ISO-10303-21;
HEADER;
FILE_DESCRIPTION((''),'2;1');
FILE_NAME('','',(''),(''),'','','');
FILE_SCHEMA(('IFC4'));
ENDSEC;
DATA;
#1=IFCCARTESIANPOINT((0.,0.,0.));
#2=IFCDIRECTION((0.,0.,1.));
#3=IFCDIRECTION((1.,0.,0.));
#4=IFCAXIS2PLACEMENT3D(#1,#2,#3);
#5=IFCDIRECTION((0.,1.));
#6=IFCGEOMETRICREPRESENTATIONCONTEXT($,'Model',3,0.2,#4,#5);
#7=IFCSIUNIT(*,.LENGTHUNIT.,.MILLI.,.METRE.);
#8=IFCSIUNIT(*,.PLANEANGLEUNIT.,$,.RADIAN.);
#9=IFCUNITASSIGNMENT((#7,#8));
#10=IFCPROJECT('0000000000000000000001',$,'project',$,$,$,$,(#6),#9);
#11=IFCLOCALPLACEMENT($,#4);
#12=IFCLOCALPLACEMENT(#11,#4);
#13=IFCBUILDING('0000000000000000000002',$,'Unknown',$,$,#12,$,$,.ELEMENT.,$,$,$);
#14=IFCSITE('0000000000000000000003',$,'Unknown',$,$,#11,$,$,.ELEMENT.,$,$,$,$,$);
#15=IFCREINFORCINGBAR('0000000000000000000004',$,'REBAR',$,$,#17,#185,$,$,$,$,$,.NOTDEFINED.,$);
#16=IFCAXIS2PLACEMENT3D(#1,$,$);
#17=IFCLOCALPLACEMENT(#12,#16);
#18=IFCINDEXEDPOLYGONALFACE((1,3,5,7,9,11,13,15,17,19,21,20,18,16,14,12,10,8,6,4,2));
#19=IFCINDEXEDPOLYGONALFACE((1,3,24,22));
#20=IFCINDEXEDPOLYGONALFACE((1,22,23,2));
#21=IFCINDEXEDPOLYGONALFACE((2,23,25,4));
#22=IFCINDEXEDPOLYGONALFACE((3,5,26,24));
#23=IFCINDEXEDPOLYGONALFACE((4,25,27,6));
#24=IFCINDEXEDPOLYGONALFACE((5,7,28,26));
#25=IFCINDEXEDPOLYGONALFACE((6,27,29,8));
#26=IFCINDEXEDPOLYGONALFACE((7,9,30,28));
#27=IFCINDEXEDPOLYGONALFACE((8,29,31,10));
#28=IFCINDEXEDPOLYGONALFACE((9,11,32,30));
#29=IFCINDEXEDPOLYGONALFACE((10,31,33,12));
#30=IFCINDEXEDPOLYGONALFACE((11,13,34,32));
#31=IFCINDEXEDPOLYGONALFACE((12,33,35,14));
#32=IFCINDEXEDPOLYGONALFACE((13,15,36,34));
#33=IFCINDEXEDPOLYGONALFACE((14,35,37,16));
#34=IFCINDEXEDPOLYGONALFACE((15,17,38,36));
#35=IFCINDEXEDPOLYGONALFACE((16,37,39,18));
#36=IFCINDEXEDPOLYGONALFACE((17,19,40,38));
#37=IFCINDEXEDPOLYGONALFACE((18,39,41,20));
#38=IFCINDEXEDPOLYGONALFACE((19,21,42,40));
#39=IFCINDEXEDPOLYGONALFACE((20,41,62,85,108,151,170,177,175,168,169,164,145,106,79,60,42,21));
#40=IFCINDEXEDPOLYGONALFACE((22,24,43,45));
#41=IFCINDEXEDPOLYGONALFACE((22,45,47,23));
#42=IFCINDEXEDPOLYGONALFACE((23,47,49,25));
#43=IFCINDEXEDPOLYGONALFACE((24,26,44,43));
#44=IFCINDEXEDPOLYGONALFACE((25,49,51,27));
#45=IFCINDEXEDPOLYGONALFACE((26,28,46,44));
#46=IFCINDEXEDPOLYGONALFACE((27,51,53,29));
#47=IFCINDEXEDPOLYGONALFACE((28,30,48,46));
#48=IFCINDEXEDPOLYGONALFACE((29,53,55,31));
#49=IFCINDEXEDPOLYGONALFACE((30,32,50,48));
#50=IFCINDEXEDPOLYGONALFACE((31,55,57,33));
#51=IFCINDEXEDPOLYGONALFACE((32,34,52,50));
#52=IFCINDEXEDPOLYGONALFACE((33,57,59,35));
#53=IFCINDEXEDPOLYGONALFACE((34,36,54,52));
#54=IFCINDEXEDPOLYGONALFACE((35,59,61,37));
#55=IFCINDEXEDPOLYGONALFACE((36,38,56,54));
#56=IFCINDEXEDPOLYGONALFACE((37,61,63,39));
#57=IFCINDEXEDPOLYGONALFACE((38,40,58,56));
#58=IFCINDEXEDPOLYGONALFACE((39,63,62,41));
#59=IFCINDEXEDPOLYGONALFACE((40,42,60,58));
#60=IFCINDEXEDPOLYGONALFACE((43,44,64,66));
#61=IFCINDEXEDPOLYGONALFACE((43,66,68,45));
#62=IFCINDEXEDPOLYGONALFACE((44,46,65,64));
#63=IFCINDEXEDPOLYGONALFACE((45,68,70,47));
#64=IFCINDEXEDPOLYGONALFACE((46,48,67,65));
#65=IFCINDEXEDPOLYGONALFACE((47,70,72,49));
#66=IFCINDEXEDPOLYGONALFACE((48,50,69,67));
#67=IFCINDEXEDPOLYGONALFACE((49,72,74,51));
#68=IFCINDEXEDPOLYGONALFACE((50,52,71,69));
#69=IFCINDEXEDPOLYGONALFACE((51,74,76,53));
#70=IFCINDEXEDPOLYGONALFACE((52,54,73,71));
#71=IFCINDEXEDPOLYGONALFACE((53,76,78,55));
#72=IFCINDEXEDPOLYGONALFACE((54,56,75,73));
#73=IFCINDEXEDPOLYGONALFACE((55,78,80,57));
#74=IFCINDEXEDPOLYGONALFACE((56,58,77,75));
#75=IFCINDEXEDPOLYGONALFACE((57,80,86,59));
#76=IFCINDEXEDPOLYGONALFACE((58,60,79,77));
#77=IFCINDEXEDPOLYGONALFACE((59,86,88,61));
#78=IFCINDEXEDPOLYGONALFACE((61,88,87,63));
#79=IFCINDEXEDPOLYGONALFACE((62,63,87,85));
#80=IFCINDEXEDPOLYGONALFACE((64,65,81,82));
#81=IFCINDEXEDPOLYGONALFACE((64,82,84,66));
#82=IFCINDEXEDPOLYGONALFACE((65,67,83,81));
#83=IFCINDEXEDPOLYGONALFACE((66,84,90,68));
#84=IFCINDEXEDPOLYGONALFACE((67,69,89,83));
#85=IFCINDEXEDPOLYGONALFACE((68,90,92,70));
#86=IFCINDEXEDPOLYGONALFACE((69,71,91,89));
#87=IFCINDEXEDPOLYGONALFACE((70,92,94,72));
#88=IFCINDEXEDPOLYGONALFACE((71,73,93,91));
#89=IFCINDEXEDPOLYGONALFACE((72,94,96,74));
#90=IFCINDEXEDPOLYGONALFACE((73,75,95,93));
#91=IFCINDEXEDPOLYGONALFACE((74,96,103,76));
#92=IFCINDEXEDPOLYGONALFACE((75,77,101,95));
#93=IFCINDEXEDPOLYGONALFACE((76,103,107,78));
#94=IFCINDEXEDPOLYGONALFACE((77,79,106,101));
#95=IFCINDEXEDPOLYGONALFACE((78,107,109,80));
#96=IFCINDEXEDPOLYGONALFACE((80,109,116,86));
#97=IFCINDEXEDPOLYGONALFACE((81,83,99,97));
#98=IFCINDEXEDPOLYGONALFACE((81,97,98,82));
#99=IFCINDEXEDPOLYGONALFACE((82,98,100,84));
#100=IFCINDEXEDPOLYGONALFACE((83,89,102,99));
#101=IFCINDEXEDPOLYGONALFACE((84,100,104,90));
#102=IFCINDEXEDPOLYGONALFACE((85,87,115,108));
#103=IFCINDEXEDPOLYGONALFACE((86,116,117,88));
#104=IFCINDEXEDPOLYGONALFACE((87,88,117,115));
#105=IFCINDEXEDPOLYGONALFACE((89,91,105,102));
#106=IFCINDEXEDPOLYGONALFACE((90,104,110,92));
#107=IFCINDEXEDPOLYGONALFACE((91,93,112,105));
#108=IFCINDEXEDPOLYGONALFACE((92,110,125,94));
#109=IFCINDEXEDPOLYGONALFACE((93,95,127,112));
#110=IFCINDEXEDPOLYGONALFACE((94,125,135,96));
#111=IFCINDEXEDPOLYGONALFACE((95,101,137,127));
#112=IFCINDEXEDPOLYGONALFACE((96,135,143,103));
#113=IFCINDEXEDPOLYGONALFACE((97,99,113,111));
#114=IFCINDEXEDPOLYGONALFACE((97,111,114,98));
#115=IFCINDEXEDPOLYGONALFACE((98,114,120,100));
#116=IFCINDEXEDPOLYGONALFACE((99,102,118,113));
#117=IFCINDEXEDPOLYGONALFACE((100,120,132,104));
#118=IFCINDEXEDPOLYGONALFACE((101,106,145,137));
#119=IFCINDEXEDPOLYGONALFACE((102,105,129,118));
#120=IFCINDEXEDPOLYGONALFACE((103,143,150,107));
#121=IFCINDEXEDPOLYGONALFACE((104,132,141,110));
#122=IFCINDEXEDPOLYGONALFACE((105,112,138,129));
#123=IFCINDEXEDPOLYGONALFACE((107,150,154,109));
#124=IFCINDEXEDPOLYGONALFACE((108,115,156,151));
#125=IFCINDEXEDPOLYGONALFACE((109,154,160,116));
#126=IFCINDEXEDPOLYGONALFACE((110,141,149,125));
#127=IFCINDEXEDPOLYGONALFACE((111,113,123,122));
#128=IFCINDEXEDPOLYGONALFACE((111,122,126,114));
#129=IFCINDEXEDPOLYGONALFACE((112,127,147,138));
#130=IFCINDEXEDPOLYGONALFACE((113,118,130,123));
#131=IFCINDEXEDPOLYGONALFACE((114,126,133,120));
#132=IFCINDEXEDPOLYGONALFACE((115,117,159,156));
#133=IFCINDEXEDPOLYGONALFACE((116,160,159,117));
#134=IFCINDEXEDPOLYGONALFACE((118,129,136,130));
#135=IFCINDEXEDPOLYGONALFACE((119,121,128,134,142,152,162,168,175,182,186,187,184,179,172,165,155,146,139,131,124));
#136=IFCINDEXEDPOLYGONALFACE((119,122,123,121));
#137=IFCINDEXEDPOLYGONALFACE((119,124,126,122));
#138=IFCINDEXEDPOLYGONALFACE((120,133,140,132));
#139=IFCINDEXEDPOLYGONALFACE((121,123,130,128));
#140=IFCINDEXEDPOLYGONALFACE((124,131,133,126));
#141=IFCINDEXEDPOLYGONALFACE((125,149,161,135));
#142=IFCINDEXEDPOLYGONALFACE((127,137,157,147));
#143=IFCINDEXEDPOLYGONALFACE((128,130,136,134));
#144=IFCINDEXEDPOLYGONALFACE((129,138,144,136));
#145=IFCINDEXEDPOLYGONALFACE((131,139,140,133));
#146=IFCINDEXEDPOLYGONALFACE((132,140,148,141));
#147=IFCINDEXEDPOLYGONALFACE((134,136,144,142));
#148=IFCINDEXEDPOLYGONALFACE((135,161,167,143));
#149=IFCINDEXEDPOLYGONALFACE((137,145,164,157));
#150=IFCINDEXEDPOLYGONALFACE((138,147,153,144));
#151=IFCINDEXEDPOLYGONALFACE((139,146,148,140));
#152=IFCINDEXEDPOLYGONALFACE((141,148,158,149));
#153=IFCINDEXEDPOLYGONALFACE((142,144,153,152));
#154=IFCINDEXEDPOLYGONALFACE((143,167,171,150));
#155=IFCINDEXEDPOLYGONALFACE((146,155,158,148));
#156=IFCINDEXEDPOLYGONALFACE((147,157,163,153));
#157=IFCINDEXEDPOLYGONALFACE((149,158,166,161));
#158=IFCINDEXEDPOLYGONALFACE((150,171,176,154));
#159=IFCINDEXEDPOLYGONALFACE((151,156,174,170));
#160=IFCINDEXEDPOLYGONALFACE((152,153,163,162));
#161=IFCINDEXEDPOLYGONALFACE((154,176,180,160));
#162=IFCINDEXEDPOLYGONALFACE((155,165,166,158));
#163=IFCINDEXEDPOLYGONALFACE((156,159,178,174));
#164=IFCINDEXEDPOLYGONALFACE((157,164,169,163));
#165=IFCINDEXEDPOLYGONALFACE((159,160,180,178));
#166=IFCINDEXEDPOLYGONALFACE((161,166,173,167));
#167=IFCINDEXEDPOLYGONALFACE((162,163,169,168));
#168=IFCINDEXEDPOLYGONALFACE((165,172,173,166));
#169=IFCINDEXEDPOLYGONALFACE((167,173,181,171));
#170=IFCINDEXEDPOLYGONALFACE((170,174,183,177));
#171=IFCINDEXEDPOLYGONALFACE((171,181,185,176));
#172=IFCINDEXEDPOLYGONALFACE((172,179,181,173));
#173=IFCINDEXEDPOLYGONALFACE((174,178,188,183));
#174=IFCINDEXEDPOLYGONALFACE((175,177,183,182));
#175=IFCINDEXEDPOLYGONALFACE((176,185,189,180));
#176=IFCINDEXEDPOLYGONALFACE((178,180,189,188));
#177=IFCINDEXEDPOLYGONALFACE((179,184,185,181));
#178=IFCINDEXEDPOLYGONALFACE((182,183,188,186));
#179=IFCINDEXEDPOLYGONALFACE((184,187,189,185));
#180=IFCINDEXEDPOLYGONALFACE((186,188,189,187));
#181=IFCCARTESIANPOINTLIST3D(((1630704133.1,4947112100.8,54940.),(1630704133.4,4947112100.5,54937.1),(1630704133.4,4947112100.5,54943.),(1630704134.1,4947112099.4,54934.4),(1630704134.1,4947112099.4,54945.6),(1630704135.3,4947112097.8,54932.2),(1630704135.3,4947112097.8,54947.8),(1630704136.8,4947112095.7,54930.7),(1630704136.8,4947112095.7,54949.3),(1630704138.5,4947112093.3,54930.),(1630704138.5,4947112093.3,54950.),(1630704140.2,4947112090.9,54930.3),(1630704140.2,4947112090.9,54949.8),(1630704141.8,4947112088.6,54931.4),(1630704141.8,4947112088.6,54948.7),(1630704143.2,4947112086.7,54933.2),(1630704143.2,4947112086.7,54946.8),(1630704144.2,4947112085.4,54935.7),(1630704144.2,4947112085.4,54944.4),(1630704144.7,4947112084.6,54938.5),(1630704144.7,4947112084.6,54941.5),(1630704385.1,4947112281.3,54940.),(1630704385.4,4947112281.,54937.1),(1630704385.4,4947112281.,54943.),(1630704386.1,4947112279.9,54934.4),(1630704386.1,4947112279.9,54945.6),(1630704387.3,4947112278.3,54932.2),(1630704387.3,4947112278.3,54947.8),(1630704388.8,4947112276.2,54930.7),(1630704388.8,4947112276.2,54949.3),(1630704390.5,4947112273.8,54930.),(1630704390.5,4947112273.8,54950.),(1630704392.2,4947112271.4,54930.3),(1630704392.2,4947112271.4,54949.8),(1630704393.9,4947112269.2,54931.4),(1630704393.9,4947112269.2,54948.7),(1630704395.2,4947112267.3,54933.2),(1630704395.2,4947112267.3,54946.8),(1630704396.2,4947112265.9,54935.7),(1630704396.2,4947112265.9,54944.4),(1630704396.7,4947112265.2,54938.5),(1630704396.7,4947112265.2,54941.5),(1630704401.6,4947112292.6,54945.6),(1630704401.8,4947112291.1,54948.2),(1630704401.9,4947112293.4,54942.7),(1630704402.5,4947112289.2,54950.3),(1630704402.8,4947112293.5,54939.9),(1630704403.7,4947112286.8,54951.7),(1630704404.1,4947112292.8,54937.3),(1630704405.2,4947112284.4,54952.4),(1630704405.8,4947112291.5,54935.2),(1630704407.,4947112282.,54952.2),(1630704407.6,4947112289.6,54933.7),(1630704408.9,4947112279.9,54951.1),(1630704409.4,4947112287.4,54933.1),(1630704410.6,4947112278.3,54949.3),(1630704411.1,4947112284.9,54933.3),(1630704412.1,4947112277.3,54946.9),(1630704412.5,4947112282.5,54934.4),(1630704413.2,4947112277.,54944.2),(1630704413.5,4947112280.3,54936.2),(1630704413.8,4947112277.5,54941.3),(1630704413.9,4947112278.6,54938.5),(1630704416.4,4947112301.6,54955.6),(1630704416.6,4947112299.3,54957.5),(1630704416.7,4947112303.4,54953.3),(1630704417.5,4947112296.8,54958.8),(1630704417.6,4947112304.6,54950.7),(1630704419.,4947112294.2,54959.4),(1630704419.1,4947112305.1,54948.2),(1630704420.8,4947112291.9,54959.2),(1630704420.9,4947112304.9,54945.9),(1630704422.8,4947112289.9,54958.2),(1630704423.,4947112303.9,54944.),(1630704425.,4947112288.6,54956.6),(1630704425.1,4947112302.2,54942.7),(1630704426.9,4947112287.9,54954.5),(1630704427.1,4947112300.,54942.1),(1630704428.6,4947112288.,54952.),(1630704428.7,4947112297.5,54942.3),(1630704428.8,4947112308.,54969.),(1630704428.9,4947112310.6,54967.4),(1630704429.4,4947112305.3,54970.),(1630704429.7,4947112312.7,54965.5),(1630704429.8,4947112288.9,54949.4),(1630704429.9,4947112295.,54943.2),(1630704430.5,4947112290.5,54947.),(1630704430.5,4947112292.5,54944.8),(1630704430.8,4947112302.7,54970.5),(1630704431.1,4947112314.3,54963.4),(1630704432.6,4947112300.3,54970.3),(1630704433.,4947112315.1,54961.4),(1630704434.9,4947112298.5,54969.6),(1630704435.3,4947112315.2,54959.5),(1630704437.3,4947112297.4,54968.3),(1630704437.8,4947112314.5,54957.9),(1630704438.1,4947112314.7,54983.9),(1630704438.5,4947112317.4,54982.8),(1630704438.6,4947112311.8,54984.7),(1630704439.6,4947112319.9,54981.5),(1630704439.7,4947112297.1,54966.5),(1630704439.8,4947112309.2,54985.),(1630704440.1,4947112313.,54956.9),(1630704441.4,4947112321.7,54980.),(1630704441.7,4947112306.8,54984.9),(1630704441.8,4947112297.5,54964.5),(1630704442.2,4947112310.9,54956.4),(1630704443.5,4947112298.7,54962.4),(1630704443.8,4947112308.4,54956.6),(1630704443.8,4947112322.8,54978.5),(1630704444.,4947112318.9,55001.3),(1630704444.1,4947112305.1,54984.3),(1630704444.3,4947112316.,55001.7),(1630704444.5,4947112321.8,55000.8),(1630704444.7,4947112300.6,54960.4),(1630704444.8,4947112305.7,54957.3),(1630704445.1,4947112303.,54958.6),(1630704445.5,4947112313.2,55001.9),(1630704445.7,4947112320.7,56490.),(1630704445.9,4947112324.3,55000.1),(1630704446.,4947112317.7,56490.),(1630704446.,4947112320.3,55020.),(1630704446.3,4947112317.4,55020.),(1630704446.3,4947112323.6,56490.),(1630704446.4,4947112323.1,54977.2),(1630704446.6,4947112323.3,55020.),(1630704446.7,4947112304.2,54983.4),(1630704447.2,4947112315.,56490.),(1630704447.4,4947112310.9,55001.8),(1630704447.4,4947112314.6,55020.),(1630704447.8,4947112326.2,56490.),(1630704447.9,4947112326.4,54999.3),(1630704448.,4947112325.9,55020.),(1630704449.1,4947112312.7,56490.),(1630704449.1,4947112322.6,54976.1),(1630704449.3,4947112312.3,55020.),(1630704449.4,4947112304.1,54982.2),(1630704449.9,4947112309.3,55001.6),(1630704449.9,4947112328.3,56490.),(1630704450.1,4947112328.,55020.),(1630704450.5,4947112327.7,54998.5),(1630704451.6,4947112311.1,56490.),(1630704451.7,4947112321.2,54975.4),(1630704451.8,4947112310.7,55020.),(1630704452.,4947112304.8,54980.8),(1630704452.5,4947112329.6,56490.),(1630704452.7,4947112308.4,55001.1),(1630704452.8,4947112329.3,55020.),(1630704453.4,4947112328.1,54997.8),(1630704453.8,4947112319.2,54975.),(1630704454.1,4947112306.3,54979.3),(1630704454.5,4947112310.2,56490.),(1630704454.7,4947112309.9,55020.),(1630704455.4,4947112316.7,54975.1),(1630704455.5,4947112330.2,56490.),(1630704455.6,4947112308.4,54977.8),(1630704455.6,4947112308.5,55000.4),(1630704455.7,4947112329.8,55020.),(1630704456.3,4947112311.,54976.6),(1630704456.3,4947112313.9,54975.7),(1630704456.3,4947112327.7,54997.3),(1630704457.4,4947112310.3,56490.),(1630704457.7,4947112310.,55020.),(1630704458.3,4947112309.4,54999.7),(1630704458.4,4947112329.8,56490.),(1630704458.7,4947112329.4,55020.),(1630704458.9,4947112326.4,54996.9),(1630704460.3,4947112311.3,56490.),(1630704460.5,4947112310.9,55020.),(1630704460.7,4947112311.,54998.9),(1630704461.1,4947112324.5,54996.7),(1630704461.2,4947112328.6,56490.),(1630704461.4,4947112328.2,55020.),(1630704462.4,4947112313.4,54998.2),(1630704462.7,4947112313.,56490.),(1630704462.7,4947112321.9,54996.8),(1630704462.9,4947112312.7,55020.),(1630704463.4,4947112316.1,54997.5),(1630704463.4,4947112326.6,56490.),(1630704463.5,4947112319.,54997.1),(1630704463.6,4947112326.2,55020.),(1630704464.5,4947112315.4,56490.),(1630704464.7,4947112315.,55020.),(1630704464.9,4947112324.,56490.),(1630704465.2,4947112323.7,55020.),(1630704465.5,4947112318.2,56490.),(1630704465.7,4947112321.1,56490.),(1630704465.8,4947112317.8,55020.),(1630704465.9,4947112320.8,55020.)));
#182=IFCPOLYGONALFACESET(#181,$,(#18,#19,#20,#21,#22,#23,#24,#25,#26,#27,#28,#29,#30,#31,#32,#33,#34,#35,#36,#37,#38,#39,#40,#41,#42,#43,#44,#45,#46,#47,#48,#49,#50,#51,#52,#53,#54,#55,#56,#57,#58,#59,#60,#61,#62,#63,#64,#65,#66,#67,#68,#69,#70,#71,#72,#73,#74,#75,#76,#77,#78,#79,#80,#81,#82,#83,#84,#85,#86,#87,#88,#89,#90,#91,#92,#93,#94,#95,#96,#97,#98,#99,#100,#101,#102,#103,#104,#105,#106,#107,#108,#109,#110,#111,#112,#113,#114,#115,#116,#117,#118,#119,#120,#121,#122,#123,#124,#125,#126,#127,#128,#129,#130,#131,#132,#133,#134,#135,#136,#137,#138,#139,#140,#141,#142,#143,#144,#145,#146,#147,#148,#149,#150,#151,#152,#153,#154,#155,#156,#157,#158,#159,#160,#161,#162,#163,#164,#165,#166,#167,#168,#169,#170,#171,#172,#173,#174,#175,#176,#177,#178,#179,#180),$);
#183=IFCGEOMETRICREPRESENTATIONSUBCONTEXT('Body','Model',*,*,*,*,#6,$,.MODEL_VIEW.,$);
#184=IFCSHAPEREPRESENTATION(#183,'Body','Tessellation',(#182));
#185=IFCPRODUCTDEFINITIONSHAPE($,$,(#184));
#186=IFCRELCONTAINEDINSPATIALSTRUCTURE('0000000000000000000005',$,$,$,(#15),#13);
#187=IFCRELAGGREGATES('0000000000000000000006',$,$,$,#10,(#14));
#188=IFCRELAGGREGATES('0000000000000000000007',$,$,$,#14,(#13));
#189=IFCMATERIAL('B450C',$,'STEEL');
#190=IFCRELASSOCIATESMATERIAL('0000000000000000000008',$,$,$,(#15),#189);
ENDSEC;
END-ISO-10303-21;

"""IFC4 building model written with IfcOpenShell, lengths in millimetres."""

from ifc_helpers import new_model, entity, si_unit, direction, frame, origin_with_axes, place, context, subcontext, project, spatial, material, element, save


model = new_model("IFC4")

# Units and contexts
model_context = context("Model", 3, precision=0.2, world=origin_with_axes(), true_north=direction((0.0, 1.0)))
body_context = subcontext(model_context, "Body", "Model", "MODEL_VIEW")
ifc_project = project(units=[si_unit("LENGTHUNIT", "METRE", prefix="MILLI"), si_unit("PLANEANGLEUNIT", "RADIAN")], contexts=[model_context])

# Site, building
site_placement = place(None, origin_with_axes())
site = spatial("IfcSite", under=ifc_project, at=site_placement, Name="Unknown", CompositionType="ELEMENT")
building_placement = place(site_placement, origin_with_axes())
building = spatial("IfcBuilding", under=site, at=building_placement, Name="Unknown", CompositionType="ELEMENT")

# Reinforcing bar
ifc_material = material(Name="B450C", Category="STEEL")
reinforcing_bar_1_placement = place(building_placement, frame((1630704467.5, 4947112389.6, 54890.0), z_axis=(0.582364, -0.812928, 0.0), x_axis=(0.0, 0.0, 1.0)))
element("IfcReinforcingBar", 1, at=reinforcing_bar_1_placement, inside=building, material=ifc_material, Name="REBAR", PredefinedType="NOTDEFINED", context=body_context, shape_type="AdvancedSweptSolid", body=[
    entity("IfcSweptDiskSolid", entity("IfcIndexedPolyCurve", entity("IfcCartesianPointList3D", [[50.0, 440.0, 50.0], [50.0, 130.0, 50.0], [73.4, 73.4, 50.0], [130.0, 50.0, 50.0], [1600.0, 50.0, 49.5]]), [entity("IfcLineIndex", [1, 2]), entity("IfcArcIndex", [2, 3, 4]), entity("IfcLineIndex", [4, 5])]), 10.0),
])

save(model, "model.ifc")
